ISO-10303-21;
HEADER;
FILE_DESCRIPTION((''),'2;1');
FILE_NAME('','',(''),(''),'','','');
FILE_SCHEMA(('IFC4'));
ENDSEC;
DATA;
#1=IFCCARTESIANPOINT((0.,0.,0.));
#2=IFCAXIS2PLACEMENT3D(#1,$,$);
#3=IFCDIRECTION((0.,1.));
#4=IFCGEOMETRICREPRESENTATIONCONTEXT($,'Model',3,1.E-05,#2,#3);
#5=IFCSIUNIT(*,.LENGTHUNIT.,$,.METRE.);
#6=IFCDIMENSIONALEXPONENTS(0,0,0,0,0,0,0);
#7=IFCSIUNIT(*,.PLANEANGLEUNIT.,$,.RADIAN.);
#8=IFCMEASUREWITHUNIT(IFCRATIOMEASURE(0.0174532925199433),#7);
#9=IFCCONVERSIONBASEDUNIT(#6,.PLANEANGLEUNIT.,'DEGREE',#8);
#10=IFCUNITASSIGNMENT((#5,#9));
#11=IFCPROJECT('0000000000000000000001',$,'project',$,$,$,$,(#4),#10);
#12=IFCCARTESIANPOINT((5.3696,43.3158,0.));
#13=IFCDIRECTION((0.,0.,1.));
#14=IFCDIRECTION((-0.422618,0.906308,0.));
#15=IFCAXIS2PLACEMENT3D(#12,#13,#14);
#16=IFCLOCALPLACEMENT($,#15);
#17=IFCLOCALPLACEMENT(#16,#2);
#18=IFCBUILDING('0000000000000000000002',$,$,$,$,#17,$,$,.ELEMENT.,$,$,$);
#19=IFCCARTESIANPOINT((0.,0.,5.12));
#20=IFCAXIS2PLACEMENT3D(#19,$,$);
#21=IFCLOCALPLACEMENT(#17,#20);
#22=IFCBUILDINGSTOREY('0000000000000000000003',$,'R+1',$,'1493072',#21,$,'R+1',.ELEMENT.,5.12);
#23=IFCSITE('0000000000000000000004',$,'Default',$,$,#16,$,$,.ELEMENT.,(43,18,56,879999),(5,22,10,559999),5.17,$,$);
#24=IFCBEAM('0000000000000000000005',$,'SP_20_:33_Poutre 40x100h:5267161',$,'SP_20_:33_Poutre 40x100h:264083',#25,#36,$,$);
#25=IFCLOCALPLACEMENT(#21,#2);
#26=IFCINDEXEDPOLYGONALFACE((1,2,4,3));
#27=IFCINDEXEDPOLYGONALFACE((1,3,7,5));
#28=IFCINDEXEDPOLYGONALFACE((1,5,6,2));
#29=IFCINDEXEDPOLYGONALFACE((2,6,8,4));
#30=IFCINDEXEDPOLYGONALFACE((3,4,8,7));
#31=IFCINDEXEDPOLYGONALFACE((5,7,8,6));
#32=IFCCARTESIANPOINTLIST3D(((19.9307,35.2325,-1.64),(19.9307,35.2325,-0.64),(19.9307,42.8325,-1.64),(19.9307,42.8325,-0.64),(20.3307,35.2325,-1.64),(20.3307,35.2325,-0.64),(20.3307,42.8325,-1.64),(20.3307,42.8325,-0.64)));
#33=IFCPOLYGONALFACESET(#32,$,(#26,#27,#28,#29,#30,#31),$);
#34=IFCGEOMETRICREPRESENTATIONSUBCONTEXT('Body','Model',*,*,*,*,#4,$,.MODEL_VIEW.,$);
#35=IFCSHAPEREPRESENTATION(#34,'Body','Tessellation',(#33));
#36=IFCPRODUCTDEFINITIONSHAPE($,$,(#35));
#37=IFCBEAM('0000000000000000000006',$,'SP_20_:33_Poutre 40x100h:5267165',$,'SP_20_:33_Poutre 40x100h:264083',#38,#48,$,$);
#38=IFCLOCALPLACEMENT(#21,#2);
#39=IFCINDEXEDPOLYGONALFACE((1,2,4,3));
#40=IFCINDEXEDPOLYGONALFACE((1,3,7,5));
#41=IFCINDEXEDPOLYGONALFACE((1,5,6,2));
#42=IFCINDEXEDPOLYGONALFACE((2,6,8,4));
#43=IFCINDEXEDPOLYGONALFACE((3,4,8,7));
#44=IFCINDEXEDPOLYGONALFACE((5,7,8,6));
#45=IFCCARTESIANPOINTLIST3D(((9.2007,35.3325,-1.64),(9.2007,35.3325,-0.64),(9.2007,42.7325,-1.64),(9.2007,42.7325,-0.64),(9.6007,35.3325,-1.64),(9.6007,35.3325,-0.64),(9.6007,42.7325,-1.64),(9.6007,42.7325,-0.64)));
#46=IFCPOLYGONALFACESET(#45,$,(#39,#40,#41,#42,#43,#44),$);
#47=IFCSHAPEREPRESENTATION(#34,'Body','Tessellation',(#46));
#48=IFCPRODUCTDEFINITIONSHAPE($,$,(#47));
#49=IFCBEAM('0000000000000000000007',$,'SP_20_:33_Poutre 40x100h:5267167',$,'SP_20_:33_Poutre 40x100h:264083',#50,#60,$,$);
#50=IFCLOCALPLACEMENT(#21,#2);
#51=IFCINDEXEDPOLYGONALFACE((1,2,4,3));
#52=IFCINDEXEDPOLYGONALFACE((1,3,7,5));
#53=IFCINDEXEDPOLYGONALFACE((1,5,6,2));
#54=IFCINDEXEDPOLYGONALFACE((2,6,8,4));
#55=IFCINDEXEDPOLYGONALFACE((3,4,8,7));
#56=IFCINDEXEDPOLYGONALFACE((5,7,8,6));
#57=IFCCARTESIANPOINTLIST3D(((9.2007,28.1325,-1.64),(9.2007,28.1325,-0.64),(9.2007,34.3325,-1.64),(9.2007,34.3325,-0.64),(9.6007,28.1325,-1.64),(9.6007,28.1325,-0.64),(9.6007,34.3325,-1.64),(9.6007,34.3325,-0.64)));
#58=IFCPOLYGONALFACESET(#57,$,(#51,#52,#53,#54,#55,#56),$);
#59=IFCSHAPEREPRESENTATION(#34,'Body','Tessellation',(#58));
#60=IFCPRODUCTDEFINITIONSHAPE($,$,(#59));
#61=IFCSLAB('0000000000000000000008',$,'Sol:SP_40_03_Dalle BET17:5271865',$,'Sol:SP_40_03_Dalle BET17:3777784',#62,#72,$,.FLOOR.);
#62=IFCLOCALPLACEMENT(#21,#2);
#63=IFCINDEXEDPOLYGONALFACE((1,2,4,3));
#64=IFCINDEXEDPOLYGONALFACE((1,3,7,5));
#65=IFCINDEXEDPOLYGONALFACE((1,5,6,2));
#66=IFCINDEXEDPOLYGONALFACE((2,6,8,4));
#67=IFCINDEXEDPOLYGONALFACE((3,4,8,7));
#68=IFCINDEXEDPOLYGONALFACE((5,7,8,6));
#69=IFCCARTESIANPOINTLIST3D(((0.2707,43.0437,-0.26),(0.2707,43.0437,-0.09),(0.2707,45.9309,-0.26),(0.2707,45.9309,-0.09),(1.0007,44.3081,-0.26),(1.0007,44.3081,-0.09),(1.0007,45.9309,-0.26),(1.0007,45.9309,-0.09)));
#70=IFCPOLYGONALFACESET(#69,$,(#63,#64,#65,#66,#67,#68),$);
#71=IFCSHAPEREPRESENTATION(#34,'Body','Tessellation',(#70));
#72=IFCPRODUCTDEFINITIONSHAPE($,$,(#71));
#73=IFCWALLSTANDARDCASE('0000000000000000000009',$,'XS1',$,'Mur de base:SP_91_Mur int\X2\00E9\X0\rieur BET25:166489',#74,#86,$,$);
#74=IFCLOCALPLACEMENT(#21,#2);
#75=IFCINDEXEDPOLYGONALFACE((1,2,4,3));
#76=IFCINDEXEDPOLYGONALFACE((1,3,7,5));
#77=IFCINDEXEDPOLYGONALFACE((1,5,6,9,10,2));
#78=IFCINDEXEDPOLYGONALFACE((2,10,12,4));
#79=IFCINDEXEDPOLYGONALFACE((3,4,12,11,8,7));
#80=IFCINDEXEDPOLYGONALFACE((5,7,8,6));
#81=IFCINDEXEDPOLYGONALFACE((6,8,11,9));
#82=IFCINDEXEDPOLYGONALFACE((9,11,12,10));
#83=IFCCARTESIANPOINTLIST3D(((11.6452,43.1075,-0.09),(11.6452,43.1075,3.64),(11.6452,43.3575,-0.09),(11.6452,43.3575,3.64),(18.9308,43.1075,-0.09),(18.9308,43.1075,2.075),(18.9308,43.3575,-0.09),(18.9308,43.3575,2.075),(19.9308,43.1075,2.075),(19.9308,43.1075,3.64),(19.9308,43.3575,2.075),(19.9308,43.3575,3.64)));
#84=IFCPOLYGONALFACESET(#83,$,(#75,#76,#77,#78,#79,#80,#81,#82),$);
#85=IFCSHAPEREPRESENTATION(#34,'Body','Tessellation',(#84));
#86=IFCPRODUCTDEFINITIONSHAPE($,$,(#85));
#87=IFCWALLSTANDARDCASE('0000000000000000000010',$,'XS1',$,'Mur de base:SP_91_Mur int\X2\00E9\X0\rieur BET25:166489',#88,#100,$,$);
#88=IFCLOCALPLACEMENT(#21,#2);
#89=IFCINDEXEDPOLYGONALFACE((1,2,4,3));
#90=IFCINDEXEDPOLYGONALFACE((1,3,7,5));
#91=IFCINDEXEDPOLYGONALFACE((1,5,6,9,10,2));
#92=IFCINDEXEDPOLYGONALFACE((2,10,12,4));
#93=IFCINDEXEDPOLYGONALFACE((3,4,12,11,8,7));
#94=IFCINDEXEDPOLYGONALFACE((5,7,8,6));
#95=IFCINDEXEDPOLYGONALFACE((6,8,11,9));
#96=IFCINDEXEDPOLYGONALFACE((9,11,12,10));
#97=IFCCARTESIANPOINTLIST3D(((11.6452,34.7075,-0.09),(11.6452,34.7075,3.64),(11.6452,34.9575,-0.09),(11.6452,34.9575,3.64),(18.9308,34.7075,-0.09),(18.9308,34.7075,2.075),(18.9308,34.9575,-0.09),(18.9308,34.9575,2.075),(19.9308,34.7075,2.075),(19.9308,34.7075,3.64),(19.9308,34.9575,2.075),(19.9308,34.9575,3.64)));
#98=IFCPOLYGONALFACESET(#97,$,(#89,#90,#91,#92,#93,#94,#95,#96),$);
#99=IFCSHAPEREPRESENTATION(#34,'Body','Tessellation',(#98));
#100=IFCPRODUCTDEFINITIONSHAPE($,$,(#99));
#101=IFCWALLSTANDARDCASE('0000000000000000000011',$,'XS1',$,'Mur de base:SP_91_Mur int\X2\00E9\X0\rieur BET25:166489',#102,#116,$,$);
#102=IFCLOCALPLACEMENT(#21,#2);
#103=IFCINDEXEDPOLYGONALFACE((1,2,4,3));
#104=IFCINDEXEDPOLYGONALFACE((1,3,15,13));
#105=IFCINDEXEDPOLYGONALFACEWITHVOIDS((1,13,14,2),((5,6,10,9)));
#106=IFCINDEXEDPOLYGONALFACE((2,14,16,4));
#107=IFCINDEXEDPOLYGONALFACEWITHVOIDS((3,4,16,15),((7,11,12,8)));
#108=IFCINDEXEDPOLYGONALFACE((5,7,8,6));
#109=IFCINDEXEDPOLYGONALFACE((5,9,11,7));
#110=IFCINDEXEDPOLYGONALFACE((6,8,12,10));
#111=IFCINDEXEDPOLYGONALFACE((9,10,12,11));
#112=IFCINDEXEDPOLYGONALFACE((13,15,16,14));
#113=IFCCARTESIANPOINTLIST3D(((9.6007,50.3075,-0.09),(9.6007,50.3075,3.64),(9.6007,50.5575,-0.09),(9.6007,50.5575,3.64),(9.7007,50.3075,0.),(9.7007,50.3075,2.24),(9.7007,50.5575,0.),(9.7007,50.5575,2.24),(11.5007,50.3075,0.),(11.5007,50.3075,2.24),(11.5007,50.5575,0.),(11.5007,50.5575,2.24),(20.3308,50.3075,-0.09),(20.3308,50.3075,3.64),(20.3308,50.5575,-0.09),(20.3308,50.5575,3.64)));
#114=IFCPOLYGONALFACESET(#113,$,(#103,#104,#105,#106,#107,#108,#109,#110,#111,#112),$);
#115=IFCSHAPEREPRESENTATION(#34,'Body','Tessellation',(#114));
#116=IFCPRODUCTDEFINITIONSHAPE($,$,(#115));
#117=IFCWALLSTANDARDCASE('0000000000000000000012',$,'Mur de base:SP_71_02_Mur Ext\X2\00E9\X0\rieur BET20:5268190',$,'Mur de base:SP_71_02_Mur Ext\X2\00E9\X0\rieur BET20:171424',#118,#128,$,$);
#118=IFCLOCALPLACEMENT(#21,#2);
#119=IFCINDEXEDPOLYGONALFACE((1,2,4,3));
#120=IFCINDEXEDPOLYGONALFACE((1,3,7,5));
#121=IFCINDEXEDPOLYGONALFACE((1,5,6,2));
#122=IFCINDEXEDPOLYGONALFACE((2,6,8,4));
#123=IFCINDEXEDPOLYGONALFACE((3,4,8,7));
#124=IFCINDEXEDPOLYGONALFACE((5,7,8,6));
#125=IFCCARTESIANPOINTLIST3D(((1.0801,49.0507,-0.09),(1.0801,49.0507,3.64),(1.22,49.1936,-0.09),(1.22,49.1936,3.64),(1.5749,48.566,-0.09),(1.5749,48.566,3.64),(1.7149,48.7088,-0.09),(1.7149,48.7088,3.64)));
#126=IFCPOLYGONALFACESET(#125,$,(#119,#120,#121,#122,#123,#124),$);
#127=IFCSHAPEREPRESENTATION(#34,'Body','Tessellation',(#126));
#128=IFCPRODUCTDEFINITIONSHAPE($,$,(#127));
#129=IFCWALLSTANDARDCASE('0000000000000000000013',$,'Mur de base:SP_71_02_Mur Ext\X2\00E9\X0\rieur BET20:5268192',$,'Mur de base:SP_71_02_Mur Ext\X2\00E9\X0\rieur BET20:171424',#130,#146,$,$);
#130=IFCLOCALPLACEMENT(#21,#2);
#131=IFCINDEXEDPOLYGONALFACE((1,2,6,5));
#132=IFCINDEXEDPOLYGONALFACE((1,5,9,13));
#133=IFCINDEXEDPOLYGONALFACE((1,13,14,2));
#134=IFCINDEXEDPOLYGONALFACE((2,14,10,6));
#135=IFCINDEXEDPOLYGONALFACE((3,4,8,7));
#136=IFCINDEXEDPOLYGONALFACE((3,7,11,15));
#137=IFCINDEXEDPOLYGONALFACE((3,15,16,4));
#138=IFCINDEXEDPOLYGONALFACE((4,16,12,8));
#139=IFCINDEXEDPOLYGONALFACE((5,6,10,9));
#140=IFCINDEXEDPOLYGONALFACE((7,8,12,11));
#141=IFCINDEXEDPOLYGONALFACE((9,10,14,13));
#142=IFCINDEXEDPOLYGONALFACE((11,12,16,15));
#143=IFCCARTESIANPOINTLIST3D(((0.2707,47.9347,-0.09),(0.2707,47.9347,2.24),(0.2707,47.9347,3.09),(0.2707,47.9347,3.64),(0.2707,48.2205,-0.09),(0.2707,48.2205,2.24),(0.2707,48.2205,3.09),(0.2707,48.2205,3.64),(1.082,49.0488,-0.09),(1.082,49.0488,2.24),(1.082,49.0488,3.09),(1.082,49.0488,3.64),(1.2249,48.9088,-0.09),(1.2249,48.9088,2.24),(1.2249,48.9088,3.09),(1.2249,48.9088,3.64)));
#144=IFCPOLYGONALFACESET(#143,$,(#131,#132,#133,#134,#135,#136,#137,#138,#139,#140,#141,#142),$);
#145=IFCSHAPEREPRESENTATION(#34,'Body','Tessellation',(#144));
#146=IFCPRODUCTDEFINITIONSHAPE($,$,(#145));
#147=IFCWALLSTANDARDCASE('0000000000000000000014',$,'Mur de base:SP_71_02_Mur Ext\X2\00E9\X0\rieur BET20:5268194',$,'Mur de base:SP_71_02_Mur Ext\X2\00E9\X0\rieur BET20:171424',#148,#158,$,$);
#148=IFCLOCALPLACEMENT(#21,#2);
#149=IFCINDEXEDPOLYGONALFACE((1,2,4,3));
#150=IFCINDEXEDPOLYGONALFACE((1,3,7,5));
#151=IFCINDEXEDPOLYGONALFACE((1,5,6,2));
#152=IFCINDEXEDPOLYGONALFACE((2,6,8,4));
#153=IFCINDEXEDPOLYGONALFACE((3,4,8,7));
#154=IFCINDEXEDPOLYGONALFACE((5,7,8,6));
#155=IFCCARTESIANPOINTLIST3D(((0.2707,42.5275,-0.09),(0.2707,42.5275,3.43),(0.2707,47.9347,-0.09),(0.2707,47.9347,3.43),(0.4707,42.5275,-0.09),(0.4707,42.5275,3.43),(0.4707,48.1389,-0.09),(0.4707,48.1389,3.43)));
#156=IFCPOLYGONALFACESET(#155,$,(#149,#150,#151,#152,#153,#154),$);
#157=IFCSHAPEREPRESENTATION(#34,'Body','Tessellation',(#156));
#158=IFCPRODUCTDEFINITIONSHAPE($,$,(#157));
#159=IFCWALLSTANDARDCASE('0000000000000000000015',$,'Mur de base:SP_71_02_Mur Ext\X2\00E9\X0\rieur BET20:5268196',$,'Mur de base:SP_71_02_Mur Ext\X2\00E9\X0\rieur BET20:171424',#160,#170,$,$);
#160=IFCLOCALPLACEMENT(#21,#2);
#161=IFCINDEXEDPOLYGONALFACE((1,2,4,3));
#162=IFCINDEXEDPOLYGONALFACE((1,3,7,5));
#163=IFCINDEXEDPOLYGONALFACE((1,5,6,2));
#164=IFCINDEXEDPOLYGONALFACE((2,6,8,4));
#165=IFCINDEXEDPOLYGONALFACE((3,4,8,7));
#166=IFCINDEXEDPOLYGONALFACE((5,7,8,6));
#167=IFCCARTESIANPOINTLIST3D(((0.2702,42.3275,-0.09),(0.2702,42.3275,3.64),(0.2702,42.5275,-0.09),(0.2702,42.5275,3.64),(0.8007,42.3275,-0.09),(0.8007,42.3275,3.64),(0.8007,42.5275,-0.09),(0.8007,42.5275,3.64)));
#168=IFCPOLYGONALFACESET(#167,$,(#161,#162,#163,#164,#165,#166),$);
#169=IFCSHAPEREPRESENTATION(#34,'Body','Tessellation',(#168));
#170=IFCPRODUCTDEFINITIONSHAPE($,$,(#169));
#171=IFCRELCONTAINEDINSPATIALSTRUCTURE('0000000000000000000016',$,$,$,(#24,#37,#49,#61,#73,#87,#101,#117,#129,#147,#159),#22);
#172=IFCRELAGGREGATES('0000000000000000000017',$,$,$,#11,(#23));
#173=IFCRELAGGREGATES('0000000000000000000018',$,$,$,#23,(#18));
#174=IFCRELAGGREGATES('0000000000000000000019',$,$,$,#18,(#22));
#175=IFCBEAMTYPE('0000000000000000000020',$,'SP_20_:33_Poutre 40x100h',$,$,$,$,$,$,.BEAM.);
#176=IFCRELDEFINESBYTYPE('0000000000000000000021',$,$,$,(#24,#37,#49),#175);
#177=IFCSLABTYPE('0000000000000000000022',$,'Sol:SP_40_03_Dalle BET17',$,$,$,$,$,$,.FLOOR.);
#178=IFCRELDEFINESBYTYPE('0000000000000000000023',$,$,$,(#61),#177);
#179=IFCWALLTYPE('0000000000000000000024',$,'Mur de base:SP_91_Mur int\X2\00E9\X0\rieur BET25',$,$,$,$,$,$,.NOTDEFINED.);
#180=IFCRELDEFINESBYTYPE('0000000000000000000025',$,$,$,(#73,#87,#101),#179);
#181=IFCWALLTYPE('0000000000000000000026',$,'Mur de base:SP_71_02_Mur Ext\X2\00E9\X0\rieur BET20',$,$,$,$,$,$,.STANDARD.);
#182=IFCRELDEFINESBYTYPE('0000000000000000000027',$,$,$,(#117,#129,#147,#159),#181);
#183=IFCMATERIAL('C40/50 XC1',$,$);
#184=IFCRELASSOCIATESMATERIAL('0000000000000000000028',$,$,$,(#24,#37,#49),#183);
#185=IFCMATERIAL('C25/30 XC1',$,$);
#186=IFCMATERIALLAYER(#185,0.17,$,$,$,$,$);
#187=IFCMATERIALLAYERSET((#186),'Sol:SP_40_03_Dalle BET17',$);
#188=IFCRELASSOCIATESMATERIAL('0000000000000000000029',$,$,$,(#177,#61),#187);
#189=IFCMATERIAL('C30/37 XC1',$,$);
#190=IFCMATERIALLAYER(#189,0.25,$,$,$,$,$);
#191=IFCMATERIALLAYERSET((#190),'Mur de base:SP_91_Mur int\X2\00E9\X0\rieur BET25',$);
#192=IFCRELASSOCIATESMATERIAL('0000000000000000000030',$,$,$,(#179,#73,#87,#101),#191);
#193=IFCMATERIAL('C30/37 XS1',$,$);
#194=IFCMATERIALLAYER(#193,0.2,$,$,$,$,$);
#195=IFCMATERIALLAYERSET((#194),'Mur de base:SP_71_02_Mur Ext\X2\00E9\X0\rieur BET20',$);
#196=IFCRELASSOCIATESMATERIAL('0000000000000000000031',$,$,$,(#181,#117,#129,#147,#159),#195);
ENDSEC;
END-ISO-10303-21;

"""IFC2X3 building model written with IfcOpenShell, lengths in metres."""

from ifc_helpers import new_model, entity, si_unit, converted_unit, direction, frame, frame_2d, origin, place, context, subcontext, project, spatial, polyline, rectangle, outline, extrude, clip, bounded_halfspace, material, layer, layer_set, layer_usage, type_object, element, save


model = new_model("IFC2X3")

# Units and contexts
model_context = context("Model", 3, precision=1e-05, world=origin(), true_north=direction((0.0, 1.0)))
body_context = subcontext(model_context, "Body", "Model", "MODEL_VIEW")
ifc_project = project(units=[si_unit("LENGTHUNIT", "METRE"), converted_unit("PLANEANGLEUNIT", "DEGREE", entity("IfcRatioMeasure", 0.0174532925199433), si_unit("PLANEANGLEUNIT", "RADIAN"), dimensions=[0, 0, 0, 0, 0, 0, 0])], contexts=[model_context])

# Site, building, storey
site_placement = place(None, frame((5.3696, 43.3158, 0.0), z_axis=(0.0, 0.0, 1.0), x_axis=(-0.422618, 0.906308, 0.0)))
site = spatial("IfcSite", under=ifc_project, at=site_placement, Name="Default", CompositionType="ELEMENT", RefLatitude=(43, 18, 56, 879999), RefLongitude=(5, 22, 10, 559999), RefElevation=5.17)
building_placement = place(site_placement, origin())
building = spatial("IfcBuilding", under=site, at=building_placement, CompositionType="ELEMENT")
storey_placement = place(building_placement, frame((0.0, 0.0, 5.12)))
storey = spatial("IfcBuildingStorey", under=building, at=storey_placement, Name="R+1", ObjectType="1493072", LongName="R+1", CompositionType="ELEMENT", Elevation=5.12)

# Beams
ifc_material_1 = material(Name="C40/50 XC1")
beam_type_1 = type_object("IfcBeamType", Name="SP_20_:33_Poutre 40x100h", PredefinedType="BEAM")
beam_1_placement = place(storey_placement, frame((20.1307, 42.8325, -0.64), z_axis=(0.0, 0.0, 1.0), x_axis=(0.0, -1.0, 0.0)))
element("IfcBeam", 1, at=beam_1_placement, inside=storey, type_object=beam_type_1, material=ifc_material_1, Name="SP_20_:33_Poutre 40x100h:5267161", ObjectType="SP_20_:33_Poutre 40x100h:264083", context=body_context, shape_type="SweptSolid", body=[
    extrude(rectangle(XDim=1.0, YDim=0.4, at=frame_2d((0.0, 0.0), x_axis=(1.0, 0.0))), frame((0.0, 0.0, -0.5), z_axis=(1.0, 0.0, 0.0), x_axis=(0.0, 0.0, -1.0)), (0.0, 0.0, 1.0), 7.6),
])
beam_2_placement = place(storey_placement, frame((9.4007, 42.7325, -0.64), z_axis=(0.0, 0.0, 1.0), x_axis=(0.0, -1.0, 0.0)))
element("IfcBeam", 2, at=beam_2_placement, inside=storey, type_object=beam_type_1, material=ifc_material_1, Name="SP_20_:33_Poutre 40x100h:5267165", ObjectType="SP_20_:33_Poutre 40x100h:264083", context=body_context, shape_type="SweptSolid", body=[
    extrude(rectangle(XDim=1.0, YDim=0.4, at=frame_2d((0.0, 0.0), x_axis=(1.0, 0.0))), frame((0.0, 0.0, -0.5), z_axis=(1.0, 0.0, 0.0), x_axis=(0.0, 0.0, -1.0)), (0.0, 0.0, 1.0), 7.4),
])
beam_3_placement = place(storey_placement, frame((9.4007, 34.3325, -0.64), z_axis=(0.0, 0.0, 1.0), x_axis=(0.0, -1.0, 0.0)))
element("IfcBeam", 3, at=beam_3_placement, inside=storey, type_object=beam_type_1, material=ifc_material_1, Name="SP_20_:33_Poutre 40x100h:5267167", ObjectType="SP_20_:33_Poutre 40x100h:264083", context=body_context, shape_type="SweptSolid", body=[
    extrude(rectangle(XDim=1.0, YDim=0.4, at=frame_2d((0.0, 0.0), x_axis=(1.0, 0.0))), frame((0.0, 0.0, -0.5), z_axis=(1.0, 0.0, 0.0), x_axis=(0.0, 0.0, -1.0)), (0.0, 0.0, 1.0), 6.2),
])
ifc_material_2 = material(Name="C30/37 XS1")

# Slab
ifc_material_3 = material(Name="C25/30 XC1")
ifc_layer_1 = layer(ifc_material_3, 0.17)
ifc_layer_set_1 = layer_set([ifc_layer_1], Name="Sol:SP_40_03_Dalle BET17")
ifc_layer_usage_1 = layer_usage(ifc_layer_set_1, "AXIS3", "POSITIVE", 0.0)
slab_type = type_object("IfcSlabType", Name="Sol:SP_40_03_Dalle BET17", PredefinedType="FLOOR", material=ifc_layer_set_1)
slab_placement = place(storey_placement, frame((0.2707, 43.0437, -0.26)))
element("IfcSlab", 4, at=slab_placement, inside=storey, type_object=slab_type, material=ifc_layer_usage_1, Name="Sol:SP_40_03_Dalle BET17:5271865", ObjectType="Sol:SP_40_03_Dalle BET17:3777784", PredefinedType="FLOOR", context=body_context, shape_type="SweptSolid", body=[
    extrude(outline(polyline([(0.365, 1.4436), (-0.365, 1.4436), (-0.365, -0.1792), (0.365, -1.4436), (0.365, 1.4436)])), frame((0.365, 1.4436, 0.17), z_axis=(0.0, 0.0, -1.0), x_axis=(-1.0, 0.0, 0.0)), (0.0, 0.0, 1.0), 0.17),
])

# Wall, opening
ifc_material_4 = material(Name="C30/37 XC1")
ifc_layer_2 = layer(ifc_material_4, 0.25)
ifc_layer_set_2 = layer_set([ifc_layer_2], Name="Mur de base:SP_91_Mur intérieur BET25")
ifc_layer_usage_2 = layer_usage(ifc_layer_set_2, "AXIS2", "NEGATIVE", 0.125)
wall_type_1 = type_object("IfcWallType", Name="Mur de base:SP_91_Mur intérieur BET25", PredefinedType="NOTDEFINED", material=ifc_layer_set_2)
wall_1_placement = place(storey_placement, frame((11.6452, 43.2325, -0.09)))
wall_1 = element("IfcWallStandardCase", 5, at=wall_1_placement, inside=storey, type_object=wall_type_1, material=ifc_layer_usage_2, Name="XS1", ObjectType="Mur de base:SP_91_Mur intérieur BET25:166489", context=body_context, shape_type="SweptSolid", body=[
    extrude(rectangle(XDim=8.2856, YDim=0.25, at=frame_2d((4.1428, 0.0), x_axis=(-1.0, 0.0))), origin(), (0.0, 0.0, 1.0), 3.73),
])
opening_1_placement = place(wall_1_placement, origin())
element("IfcOpeningElement", 6, at=opening_1_placement, cuts=wall_1, ObjectType="Opening", context=body_context, shape_type="SweptSolid", body=[
    extrude(rectangle(XDim=2.165, YDim=1.0, at=frame_2d((0.0, 0.0), x_axis=(0.0, 1.0))), frame((7.7856, -1.649, 1.0825), z_axis=(0.0, 1.0, 0.0), x_axis=(1.0, 0.0, 0.0)), (0.0, 0.0, 1.0), 3.048),
])

# Walls, openings
ifc_layer_usage_3 = layer_usage(ifc_layer_set_2, "AXIS2", "NEGATIVE", 0.125)
wall_2_placement = place(storey_placement, frame((11.6452, 34.8325, -0.09)))
wall_2 = element("IfcWallStandardCase", 7, at=wall_2_placement, inside=storey, type_object=wall_type_1, material=ifc_layer_usage_3, Name="XS1", ObjectType="Mur de base:SP_91_Mur intérieur BET25:166489", context=body_context, shape_type="SweptSolid", body=[
    extrude(rectangle(XDim=8.2856, YDim=0.25, at=frame_2d((4.1428, 0.0), x_axis=(-1.0, 0.0))), origin(), (0.0, 0.0, 1.0), 3.73),
])
opening_2_placement = place(wall_2_placement, origin())
element("IfcOpeningElement", 8, at=opening_2_placement, cuts=wall_2, ObjectType="Opening", context=body_context, shape_type="SweptSolid", body=[
    extrude(rectangle(XDim=2.165, YDim=1.0, at=frame_2d((0.0, 0.0), x_axis=(0.0, 1.0))), frame((7.7856, -1.649, 1.0825), z_axis=(0.0, 1.0, 0.0), x_axis=(1.0, 0.0, 0.0)), (0.0, 0.0, 1.0), 3.048),
])
ifc_layer_usage_4 = layer_usage(ifc_layer_set_2, "AXIS2", "NEGATIVE", 0.125)
wall_3_placement = place(storey_placement, frame((9.6007, 50.4325, -0.09)))
wall_3 = element("IfcWallStandardCase", 9, at=wall_3_placement, inside=storey, type_object=wall_type_1, material=ifc_layer_usage_4, Name="XS1", ObjectType="Mur de base:SP_91_Mur intérieur BET25:166489", context=body_context, shape_type="SweptSolid", body=[
    extrude(rectangle(XDim=10.7301, YDim=0.25, at=frame_2d((5.365, 0.0), x_axis=(-1.0, 0.0))), origin(), (0.0, 0.0, 1.0), 3.73),
])
opening_3_placement = place(wall_3_placement, origin())
element("IfcOpeningElement", 10, at=opening_3_placement, cuts=wall_3, ObjectType="Opening", context=body_context, shape_type="SweptSolid", body=[
    extrude(rectangle(XDim=2.24, YDim=1.8, at=frame_2d((0.0, 0.0), x_axis=(1.0, 0.0))), frame((1.0, -1.399, 1.21), z_axis=(0.0, 1.0, 0.0), x_axis=(0.0, 0.0, -1.0)), (0.0, 0.0, 1.0), 3.048),
])

# Wall
ifc_layer_3 = layer(ifc_material_2, 0.2)
ifc_layer_set_3 = layer_set([ifc_layer_3], Name="Mur de base:SP_71_02_Mur Extérieur BET20")
ifc_layer_usage_5 = layer_usage(ifc_layer_set_3, "AXIS2", "NEGATIVE", 0.1)
wall_type_2 = type_object("IfcWallType", Name="Mur de base:SP_71_02_Mur Extérieur BET20", PredefinedType="STANDARD", material=ifc_layer_set_3)
wall_4_placement = place(storey_placement, frame((1.6449, 48.6374, -0.09), z_axis=(0.0, 0.0, 1.0), x_axis=(-0.714364, 0.699774, 0.0)))
element("IfcWallStandardCase", 11, at=wall_4_placement, inside=storey, type_object=wall_type_2, material=ifc_layer_usage_5, Name="Mur de base:SP_71_02_Mur Extérieur BET20:5268190", ObjectType="Mur de base:SP_71_02_Mur Extérieur BET20:171424", context=body_context, shape_type="SweptSolid", body=[
    extrude(rectangle(XDim=0.6927, YDim=0.2, at=frame_2d((0.3463, 0.0), x_axis=(-1.0, 0.0))), origin(), (0.0, 0.0, 1.0), 3.73),
])

# Wall, opening
ifc_layer_usage_6 = layer_usage(ifc_layer_set_3, "AXIS2", "NEGATIVE", 0.1)
wall_5_placement = place(storey_placement, frame((1.1535, 48.9788, -0.09), z_axis=(0.0, 0.0, 1.0), x_axis=(-0.699774, -0.714364, 0.0)))
wall_5 = element("IfcWallStandardCase", 12, at=wall_5_placement, inside=storey, type_object=wall_type_2, material=ifc_layer_usage_6, Name="Mur de base:SP_71_02_Mur Extérieur BET20:5268192", ObjectType="Mur de base:SP_71_02_Mur Extérieur BET20:171424", context=body_context, shape_type="SweptSolid", body=[
    extrude(outline(polyline([(1.1595, -0.1), (1.3636, 0.1), (1.0778, 0.1), (0.0, 0.1), (0.0, -0.1), (1.1595, -0.1)])), origin(), (0.0, 0.0, 1.0), 3.73),
])
opening_4_placement = place(storey_placement, frame((1.1535, 48.9788, -0.09), z_axis=(0.0, 0.0, 1.0), x_axis=(-0.699774, -0.714364, 0.0)))
element("IfcOpeningElement", 13, at=opening_4_placement, cuts=wall_5, ObjectType="Opening", context=body_context, shape_type="SweptSolid", body=[
    extrude(outline(polyline([(-0.6308, -0.1), (0.5287, -0.1), (0.7329, 0.1), (-0.6308, 0.1), (-0.6308, -0.1)])), frame((0.6308, 0.0, 2.33)), (0.0, 0.0, 1.0), 0.85),
])

# Walls
ifc_layer_usage_7 = layer_usage(ifc_layer_set_3, "AXIS2", "NEGATIVE", 0.1)
wall_6_placement = place(storey_placement, frame((0.3707, 48.1389, -0.09), z_axis=(0.0, 0.0, 1.0), x_axis=(0.0, -1.0, 0.0)))
element("IfcWallStandardCase", 14, at=wall_6_placement, inside=storey, type_object=wall_type_2, material=ifc_layer_usage_7, Name="Mur de base:SP_71_02_Mur Extérieur BET20:5268194", ObjectType="Mur de base:SP_71_02_Mur Extérieur BET20:171424", context=body_context, shape_type="Clipping", body=[
    clip(extrude(outline(polyline([(5.6114, -0.1), (5.6114, 0.1), (5.0314, 0.1), (4.7814, 0.1), (4.3488, 0.1), (2.408, 0.1), (0.0, 0.1), (0.2042, -0.1), (2.408, -0.1), (4.6952, -0.1), (5.6114, -0.1)])), origin(), (0.0, 0.0, 1.0), 3.52), bounded_halfspace(frame((0.2042, -0.1, 3.52), z_axis=(0.0, 0.0, -1.0), x_axis=(-1.0, 0.0, 0.0)), True, frame((0.2042, -0.1, 3.52), z_axis=(0.0, 0.0, -1.0), x_axis=(-1.0, 0.0, 0.0)), polyline([(0.0, 0.0), (0.2042, 0.2), (-5.4072, 0.2), (-5.4072, 0.0), (0.0, 0.0)]))),
])
ifc_layer_usage_8 = layer_usage(ifc_layer_set_3, "AXIS2", "NEGATIVE", 0.1)
wall_7_placement = place(storey_placement, frame((0.2702, 42.4275, -0.09)))
element("IfcWallStandardCase", 15, at=wall_7_placement, inside=storey, type_object=wall_type_2, material=ifc_layer_usage_8, Name="Mur de base:SP_71_02_Mur Extérieur BET20:5268196", ObjectType="Mur de base:SP_71_02_Mur Extérieur BET20:171424", context=body_context, shape_type="SweptSolid", body=[
    extrude(rectangle(XDim=0.5305, YDim=0.2, at=frame_2d((0.2652, 0.0), x_axis=(-1.0, 0.0))), origin(), (0.0, 0.0, 1.0), 3.73),
])

save(model, "model.ifc")
